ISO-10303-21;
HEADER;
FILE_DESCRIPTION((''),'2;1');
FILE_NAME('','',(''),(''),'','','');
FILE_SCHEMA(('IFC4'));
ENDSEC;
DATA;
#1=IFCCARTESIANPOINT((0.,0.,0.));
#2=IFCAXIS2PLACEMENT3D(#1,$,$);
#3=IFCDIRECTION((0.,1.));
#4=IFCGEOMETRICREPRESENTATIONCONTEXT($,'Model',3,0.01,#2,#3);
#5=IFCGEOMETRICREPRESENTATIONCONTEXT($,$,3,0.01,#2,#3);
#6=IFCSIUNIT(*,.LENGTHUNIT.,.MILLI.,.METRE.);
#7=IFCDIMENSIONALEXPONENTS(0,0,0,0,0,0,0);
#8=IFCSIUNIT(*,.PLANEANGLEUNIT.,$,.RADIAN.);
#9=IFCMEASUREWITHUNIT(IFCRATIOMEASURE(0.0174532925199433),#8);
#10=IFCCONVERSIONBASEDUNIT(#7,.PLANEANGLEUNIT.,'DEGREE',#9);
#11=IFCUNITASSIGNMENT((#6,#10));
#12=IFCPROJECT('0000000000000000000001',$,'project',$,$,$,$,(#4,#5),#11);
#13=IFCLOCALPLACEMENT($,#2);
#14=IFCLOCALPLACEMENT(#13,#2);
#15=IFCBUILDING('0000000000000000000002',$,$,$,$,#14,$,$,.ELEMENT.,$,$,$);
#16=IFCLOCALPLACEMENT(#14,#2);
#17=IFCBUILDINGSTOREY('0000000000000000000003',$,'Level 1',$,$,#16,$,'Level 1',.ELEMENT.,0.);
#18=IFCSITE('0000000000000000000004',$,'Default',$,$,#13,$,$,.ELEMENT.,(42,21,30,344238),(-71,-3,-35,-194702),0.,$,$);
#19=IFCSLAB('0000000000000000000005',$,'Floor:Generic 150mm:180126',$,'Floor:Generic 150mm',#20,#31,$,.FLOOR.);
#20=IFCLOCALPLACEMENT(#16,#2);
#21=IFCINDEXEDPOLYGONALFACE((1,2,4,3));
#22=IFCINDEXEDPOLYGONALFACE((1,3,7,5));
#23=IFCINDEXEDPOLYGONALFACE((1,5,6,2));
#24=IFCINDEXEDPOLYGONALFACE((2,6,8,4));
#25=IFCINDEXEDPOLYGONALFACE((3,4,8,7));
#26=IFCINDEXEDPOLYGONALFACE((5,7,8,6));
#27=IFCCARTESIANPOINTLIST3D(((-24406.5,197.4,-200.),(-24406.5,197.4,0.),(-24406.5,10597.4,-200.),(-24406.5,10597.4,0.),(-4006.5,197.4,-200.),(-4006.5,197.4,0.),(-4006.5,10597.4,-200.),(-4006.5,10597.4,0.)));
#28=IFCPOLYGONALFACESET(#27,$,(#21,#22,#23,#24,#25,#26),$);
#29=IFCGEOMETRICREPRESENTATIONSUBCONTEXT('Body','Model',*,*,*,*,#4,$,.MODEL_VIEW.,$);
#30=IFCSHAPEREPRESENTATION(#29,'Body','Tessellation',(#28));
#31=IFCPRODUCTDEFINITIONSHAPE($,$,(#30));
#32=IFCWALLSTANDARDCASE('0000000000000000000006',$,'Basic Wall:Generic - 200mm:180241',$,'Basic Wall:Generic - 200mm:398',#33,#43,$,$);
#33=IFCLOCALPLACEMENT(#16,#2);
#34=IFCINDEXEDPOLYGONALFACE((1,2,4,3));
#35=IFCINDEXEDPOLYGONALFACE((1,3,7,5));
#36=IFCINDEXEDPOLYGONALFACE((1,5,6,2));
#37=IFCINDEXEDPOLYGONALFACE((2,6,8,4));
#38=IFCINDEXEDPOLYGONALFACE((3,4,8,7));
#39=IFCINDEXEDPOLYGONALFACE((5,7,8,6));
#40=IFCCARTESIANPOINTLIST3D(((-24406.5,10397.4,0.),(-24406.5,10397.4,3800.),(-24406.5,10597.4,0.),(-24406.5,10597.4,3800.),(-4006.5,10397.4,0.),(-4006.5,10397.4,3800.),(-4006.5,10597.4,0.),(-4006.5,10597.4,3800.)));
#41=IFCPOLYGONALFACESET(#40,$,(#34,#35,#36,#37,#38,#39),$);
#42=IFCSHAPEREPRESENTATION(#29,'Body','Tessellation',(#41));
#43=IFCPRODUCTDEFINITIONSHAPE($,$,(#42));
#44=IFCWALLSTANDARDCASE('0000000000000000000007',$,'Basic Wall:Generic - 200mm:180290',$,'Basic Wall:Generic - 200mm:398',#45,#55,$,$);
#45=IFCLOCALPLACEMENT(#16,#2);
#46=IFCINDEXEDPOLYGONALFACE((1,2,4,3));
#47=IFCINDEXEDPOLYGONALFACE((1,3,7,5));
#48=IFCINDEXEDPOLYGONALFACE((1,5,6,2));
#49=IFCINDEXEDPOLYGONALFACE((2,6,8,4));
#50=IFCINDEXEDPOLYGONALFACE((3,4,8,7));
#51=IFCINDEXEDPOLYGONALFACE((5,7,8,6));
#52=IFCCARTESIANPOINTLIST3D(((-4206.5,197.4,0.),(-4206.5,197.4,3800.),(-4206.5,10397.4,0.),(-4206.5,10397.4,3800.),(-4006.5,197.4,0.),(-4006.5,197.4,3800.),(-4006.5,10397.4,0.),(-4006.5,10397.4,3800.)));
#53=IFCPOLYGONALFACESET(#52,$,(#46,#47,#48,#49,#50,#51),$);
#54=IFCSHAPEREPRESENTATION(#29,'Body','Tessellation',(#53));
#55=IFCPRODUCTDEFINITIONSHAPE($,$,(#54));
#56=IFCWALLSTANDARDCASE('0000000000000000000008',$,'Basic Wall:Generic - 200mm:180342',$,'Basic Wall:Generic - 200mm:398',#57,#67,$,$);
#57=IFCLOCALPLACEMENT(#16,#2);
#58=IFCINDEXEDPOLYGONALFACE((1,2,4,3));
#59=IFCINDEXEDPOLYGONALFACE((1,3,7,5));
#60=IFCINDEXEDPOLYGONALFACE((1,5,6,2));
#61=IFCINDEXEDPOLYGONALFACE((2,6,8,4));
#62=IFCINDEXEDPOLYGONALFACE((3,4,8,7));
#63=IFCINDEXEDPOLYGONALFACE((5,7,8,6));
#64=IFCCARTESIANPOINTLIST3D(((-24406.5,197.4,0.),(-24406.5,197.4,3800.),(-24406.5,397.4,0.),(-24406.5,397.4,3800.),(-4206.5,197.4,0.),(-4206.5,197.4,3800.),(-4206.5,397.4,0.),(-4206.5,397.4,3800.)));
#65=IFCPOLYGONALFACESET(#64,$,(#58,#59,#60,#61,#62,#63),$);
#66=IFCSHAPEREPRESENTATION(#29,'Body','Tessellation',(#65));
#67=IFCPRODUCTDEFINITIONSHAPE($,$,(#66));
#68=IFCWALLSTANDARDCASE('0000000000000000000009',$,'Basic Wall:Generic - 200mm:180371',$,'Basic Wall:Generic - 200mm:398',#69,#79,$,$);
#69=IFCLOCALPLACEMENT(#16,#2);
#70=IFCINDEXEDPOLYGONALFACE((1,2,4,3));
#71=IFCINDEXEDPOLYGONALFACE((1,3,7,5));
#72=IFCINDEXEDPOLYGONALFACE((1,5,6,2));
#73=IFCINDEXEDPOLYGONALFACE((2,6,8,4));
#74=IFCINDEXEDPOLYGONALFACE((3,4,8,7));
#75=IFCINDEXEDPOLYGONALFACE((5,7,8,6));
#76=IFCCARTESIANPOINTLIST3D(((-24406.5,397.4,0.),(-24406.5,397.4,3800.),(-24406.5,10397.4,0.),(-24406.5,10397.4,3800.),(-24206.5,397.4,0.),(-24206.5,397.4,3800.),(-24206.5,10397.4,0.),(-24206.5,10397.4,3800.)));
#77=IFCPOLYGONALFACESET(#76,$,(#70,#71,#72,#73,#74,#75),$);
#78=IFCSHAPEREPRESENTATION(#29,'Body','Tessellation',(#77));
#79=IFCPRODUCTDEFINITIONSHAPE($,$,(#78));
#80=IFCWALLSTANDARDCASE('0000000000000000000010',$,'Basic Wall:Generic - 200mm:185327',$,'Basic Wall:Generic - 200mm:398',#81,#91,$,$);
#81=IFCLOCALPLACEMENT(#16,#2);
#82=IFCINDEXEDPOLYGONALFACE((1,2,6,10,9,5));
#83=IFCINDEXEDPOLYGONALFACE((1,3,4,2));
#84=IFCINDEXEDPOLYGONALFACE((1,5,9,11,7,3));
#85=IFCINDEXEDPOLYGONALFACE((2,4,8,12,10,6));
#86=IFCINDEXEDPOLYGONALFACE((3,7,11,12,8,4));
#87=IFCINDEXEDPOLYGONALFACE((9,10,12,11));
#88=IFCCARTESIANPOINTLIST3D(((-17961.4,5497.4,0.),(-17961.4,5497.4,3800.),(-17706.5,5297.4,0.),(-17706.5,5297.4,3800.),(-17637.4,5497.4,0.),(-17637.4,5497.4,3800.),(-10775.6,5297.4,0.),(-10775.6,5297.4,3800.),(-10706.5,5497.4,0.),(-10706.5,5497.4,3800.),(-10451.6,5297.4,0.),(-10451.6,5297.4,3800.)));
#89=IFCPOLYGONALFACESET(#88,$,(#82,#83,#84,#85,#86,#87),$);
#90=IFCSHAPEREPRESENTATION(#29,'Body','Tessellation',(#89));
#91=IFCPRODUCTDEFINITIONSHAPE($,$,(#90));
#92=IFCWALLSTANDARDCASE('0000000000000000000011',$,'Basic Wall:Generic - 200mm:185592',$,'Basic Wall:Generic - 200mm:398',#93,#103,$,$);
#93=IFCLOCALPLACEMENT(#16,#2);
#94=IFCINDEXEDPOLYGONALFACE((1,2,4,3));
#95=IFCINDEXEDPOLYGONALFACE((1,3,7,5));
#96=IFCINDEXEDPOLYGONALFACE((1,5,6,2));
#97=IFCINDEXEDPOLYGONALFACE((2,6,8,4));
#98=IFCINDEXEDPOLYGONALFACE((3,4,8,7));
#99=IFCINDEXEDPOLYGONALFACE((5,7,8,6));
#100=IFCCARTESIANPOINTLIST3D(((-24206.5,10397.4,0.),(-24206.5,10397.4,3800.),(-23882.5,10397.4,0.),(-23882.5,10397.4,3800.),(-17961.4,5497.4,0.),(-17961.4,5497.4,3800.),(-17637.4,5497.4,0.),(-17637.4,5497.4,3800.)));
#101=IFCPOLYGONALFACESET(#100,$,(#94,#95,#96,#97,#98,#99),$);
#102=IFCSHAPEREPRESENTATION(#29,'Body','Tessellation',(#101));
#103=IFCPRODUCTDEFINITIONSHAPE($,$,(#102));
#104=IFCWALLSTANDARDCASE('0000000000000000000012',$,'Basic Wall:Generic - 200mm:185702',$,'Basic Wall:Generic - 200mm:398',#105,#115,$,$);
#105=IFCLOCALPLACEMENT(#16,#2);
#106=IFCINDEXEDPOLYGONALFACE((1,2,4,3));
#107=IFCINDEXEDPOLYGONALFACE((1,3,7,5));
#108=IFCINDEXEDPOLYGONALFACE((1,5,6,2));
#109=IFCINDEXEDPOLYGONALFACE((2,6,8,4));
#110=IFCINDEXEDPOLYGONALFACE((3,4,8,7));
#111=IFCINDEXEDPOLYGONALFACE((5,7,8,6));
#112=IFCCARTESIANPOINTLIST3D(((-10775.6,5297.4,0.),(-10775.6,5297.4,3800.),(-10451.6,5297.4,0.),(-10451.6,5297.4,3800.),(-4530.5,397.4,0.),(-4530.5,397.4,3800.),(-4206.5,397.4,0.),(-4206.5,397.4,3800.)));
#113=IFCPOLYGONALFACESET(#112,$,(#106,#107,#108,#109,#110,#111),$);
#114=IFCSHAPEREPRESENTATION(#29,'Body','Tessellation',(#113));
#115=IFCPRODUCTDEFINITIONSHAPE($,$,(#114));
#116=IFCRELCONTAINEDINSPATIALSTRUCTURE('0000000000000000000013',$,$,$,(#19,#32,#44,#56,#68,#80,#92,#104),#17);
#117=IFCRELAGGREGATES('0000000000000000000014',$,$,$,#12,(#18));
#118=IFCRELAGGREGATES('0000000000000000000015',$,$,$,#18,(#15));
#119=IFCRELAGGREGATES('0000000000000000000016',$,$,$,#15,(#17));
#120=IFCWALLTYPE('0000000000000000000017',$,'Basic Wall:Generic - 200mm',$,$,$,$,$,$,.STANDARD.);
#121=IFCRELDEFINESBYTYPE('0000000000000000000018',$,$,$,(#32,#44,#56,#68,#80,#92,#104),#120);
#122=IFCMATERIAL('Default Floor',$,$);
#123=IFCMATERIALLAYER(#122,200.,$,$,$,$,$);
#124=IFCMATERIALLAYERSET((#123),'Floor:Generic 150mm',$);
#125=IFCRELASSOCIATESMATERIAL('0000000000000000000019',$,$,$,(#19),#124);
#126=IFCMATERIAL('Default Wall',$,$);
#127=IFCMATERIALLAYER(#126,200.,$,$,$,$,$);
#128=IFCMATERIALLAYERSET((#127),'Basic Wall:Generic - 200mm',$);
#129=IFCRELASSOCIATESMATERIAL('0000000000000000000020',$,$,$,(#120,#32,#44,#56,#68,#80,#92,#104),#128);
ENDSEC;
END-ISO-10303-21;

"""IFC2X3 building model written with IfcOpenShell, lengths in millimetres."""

from ifc_helpers import new_model, entity, si_unit, converted_unit, direction, frame, frame_2d, origin, origin_2d_with_axis, place, context, subcontext, project, spatial, polyline, rectangle, outline, extrude, material, layer, layer_set, layer_usage, type_object, element, save


model = new_model("IFC2X3")

# Units and contexts
model_context = context("Model", 3, precision=0.01, world=origin(), true_north=direction((0.0, 1.0)))
context_of_model = context(None, 3, precision=0.01, world=origin(), true_north=direction((0.0, 1.0)))
body_context = subcontext(model_context, "Body", "Model", "MODEL_VIEW")
ifc_project = project(units=[si_unit("LENGTHUNIT", "METRE", prefix="MILLI"), converted_unit("PLANEANGLEUNIT", "DEGREE", entity("IfcRatioMeasure", 0.0174532925199433), si_unit("PLANEANGLEUNIT", "RADIAN"), dimensions=[0, 0, 0, 0, 0, 0, 0])], contexts=[model_context, context_of_model])

# Site, building, storey
site_placement = place(None, origin())
site = spatial("IfcSite", under=ifc_project, at=site_placement, Name="Default", CompositionType="ELEMENT", RefLatitude=(42, 21, 30, 344238), RefLongitude=(-71, -3, -35, -194702), RefElevation=0.0)
building_placement = place(site_placement, origin())
building = spatial("IfcBuilding", under=site, at=building_placement, CompositionType="ELEMENT")
storey_placement = place(building_placement, origin())
storey = spatial("IfcBuildingStorey", under=building, at=storey_placement, Name="Level 1", LongName="Level 1", CompositionType="ELEMENT", Elevation=0.0)

# Slab
ifc_material_1 = material(Name="Default Floor")
ifc_layer_1 = layer(ifc_material_1, 200.0)
ifc_layer_set_1 = layer_set([ifc_layer_1], Name="Floor:Generic 150mm")
ifc_layer_usage_1 = layer_usage(ifc_layer_set_1, "AXIS3", "POSITIVE", 0.0)
slab_placement = place(storey_placement, origin())
element("IfcSlab", 1, at=slab_placement, inside=storey, material=ifc_layer_usage_1, Name="Floor:Generic 150mm:180126", ObjectType="Floor:Generic 150mm", PredefinedType="FLOOR", context=body_context, shape_type="SweptSolid", body=[
    extrude(rectangle(XDim=10400.0, YDim=20400.0, at=origin_2d_with_axis()), frame((-14206.5, 5397.4, 0.0), z_axis=(0.0, 0.0, -1.0), x_axis=(0.0, 1.0, 0.0)), (0.0, 0.0, 1.0), 200.0),
])

# Walls
ifc_material_2 = material(Name="Default Wall")
ifc_layer_2 = layer(ifc_material_2, 200.0)
ifc_layer_set_2 = layer_set([ifc_layer_2], Name="Basic Wall:Generic - 200mm")
ifc_layer_usage_2 = layer_usage(ifc_layer_set_2, "AXIS2", "NEGATIVE", 100.0)
wall_type = type_object("IfcWallType", Name="Basic Wall:Generic - 200mm", PredefinedType="STANDARD", material=ifc_layer_set_2)
wall_1_placement = place(storey_placement, frame((-24406.5, 10497.4, 0.0)))
element("IfcWallStandardCase", 2, at=wall_1_placement, inside=storey, type_object=wall_type, material=ifc_layer_usage_2, Name="Basic Wall:Generic - 200mm:180241", ObjectType="Basic Wall:Generic - 200mm:398", context=body_context, shape_type="SweptSolid", body=[
    extrude(rectangle(XDim=20400.0, YDim=200.0, at=frame_2d((10200.0, 0.0), x_axis=(-1.0, 0.0))), origin(), (0.0, 0.0, 1.0), 3800.0),
])
ifc_layer_usage_3 = layer_usage(ifc_layer_set_2, "AXIS2", "NEGATIVE", 100.0)
wall_2_placement = place(storey_placement, frame((-4106.5, 10397.4, 0.0), z_axis=(0.0, 0.0, 1.0), x_axis=(0.0, -1.0, 0.0)))
element("IfcWallStandardCase", 3, at=wall_2_placement, inside=storey, type_object=wall_type, material=ifc_layer_usage_3, Name="Basic Wall:Generic - 200mm:180290", ObjectType="Basic Wall:Generic - 200mm:398", context=body_context, shape_type="SweptSolid", body=[
    extrude(rectangle(XDim=10200.0, YDim=200.0, at=frame_2d((5100.0, 0.0), x_axis=(-1.0, 0.0))), origin(), (0.0, 0.0, 1.0), 3800.0),
])
ifc_layer_usage_4 = layer_usage(ifc_layer_set_2, "AXIS2", "NEGATIVE", 100.0)
wall_3_placement = place(storey_placement, frame((-4206.5, 297.4, 0.0), z_axis=(0.0, 0.0, 1.0), x_axis=(-1.0, 0.0, 0.0)))
element("IfcWallStandardCase", 4, at=wall_3_placement, inside=storey, type_object=wall_type, material=ifc_layer_usage_4, Name="Basic Wall:Generic - 200mm:180342", ObjectType="Basic Wall:Generic - 200mm:398", context=body_context, shape_type="SweptSolid", body=[
    extrude(rectangle(XDim=20200.0, YDim=200.0, at=frame_2d((10100.0, 0.0), x_axis=(-1.0, 0.0))), origin(), (0.0, 0.0, 1.0), 3800.0),
])
ifc_layer_usage_5 = layer_usage(ifc_layer_set_2, "AXIS2", "NEGATIVE", 100.0)
wall_4_placement = place(storey_placement, frame((-24306.5, 397.4, 0.0), z_axis=(0.0, 0.0, 1.0), x_axis=(0.0, 1.0, 0.0)))
element("IfcWallStandardCase", 5, at=wall_4_placement, inside=storey, type_object=wall_type, material=ifc_layer_usage_5, Name="Basic Wall:Generic - 200mm:180371", ObjectType="Basic Wall:Generic - 200mm:398", context=body_context, shape_type="SweptSolid", body=[
    extrude(rectangle(XDim=10000.0, YDim=200.0, at=frame_2d((5000.0, 0.0), x_axis=(-1.0, 0.0))), origin(), (0.0, 0.0, 1.0), 3800.0),
])
ifc_layer_usage_6 = layer_usage(ifc_layer_set_2, "AXIS2", "NEGATIVE", 100.0)
wall_5_placement = place(storey_placement, frame((-17961.4, 5397.4, 0.0)))
element("IfcWallStandardCase", 6, at=wall_5_placement, inside=storey, type_object=wall_type, material=ifc_layer_usage_6, Name="Basic Wall:Generic - 200mm:185327", ObjectType="Basic Wall:Generic - 200mm:398", context=body_context, shape_type="SweptSolid", body=[
    extrude(outline(polyline([(7509.8, -100.0), (7254.9, 100.0), (324.0, 100.0), (0.0, 100.0), (254.9, -100.0), (7185.8, -100.0), (7509.8, -100.0)])), origin(), (0.0, 0.0, 1.0), 3800.0),
])
ifc_layer_usage_7 = layer_usage(ifc_layer_set_2, "AXIS2", "NEGATIVE", 100.0)
wall_6_placement = place(storey_placement, frame((-17699.1, 5418.8, 0.0), z_axis=(0.0, 0.0, 1.0), x_axis=(-0.786738, 0.617287, 0.0)))
element("IfcWallStandardCase", 7, at=wall_6_placement, inside=storey, type_object=wall_type, material=ifc_layer_usage_7, Name="Basic Wall:Generic - 200mm:185592", ObjectType="Basic Wall:Generic - 200mm:398", context=body_context, shape_type="SweptSolid", body=[
    extrude(outline(polyline([(7938.0, -100.0), (8192.9, 100.0), (254.9, 100.0), (0.0, -100.0), (7938.0, -100.0)])), origin(), (0.0, 0.0, 1.0), 3800.0),
])
ifc_layer_usage_8 = layer_usage(ifc_layer_set_2, "AXIS2", "NEGATIVE", 100.0)
wall_7_placement = place(storey_placement, frame((-10713.8, 5376.1, 0.0), z_axis=(0.0, 0.0, 1.0), x_axis=(0.786738, -0.617287, 0.0)))
element("IfcWallStandardCase", 8, at=wall_7_placement, inside=storey, type_object=wall_type, material=ifc_layer_usage_8, Name="Basic Wall:Generic - 200mm:185702", ObjectType="Basic Wall:Generic - 200mm:398", context=body_context, shape_type="SweptSolid", body=[
    extrude(outline(polyline([(7938.0, -100.0), (8192.9, 100.0), (254.9, 100.0), (0.0, -100.0), (7938.0, -100.0)])), origin(), (0.0, 0.0, 1.0), 3800.0),
])

save(model, "model.ifc")
